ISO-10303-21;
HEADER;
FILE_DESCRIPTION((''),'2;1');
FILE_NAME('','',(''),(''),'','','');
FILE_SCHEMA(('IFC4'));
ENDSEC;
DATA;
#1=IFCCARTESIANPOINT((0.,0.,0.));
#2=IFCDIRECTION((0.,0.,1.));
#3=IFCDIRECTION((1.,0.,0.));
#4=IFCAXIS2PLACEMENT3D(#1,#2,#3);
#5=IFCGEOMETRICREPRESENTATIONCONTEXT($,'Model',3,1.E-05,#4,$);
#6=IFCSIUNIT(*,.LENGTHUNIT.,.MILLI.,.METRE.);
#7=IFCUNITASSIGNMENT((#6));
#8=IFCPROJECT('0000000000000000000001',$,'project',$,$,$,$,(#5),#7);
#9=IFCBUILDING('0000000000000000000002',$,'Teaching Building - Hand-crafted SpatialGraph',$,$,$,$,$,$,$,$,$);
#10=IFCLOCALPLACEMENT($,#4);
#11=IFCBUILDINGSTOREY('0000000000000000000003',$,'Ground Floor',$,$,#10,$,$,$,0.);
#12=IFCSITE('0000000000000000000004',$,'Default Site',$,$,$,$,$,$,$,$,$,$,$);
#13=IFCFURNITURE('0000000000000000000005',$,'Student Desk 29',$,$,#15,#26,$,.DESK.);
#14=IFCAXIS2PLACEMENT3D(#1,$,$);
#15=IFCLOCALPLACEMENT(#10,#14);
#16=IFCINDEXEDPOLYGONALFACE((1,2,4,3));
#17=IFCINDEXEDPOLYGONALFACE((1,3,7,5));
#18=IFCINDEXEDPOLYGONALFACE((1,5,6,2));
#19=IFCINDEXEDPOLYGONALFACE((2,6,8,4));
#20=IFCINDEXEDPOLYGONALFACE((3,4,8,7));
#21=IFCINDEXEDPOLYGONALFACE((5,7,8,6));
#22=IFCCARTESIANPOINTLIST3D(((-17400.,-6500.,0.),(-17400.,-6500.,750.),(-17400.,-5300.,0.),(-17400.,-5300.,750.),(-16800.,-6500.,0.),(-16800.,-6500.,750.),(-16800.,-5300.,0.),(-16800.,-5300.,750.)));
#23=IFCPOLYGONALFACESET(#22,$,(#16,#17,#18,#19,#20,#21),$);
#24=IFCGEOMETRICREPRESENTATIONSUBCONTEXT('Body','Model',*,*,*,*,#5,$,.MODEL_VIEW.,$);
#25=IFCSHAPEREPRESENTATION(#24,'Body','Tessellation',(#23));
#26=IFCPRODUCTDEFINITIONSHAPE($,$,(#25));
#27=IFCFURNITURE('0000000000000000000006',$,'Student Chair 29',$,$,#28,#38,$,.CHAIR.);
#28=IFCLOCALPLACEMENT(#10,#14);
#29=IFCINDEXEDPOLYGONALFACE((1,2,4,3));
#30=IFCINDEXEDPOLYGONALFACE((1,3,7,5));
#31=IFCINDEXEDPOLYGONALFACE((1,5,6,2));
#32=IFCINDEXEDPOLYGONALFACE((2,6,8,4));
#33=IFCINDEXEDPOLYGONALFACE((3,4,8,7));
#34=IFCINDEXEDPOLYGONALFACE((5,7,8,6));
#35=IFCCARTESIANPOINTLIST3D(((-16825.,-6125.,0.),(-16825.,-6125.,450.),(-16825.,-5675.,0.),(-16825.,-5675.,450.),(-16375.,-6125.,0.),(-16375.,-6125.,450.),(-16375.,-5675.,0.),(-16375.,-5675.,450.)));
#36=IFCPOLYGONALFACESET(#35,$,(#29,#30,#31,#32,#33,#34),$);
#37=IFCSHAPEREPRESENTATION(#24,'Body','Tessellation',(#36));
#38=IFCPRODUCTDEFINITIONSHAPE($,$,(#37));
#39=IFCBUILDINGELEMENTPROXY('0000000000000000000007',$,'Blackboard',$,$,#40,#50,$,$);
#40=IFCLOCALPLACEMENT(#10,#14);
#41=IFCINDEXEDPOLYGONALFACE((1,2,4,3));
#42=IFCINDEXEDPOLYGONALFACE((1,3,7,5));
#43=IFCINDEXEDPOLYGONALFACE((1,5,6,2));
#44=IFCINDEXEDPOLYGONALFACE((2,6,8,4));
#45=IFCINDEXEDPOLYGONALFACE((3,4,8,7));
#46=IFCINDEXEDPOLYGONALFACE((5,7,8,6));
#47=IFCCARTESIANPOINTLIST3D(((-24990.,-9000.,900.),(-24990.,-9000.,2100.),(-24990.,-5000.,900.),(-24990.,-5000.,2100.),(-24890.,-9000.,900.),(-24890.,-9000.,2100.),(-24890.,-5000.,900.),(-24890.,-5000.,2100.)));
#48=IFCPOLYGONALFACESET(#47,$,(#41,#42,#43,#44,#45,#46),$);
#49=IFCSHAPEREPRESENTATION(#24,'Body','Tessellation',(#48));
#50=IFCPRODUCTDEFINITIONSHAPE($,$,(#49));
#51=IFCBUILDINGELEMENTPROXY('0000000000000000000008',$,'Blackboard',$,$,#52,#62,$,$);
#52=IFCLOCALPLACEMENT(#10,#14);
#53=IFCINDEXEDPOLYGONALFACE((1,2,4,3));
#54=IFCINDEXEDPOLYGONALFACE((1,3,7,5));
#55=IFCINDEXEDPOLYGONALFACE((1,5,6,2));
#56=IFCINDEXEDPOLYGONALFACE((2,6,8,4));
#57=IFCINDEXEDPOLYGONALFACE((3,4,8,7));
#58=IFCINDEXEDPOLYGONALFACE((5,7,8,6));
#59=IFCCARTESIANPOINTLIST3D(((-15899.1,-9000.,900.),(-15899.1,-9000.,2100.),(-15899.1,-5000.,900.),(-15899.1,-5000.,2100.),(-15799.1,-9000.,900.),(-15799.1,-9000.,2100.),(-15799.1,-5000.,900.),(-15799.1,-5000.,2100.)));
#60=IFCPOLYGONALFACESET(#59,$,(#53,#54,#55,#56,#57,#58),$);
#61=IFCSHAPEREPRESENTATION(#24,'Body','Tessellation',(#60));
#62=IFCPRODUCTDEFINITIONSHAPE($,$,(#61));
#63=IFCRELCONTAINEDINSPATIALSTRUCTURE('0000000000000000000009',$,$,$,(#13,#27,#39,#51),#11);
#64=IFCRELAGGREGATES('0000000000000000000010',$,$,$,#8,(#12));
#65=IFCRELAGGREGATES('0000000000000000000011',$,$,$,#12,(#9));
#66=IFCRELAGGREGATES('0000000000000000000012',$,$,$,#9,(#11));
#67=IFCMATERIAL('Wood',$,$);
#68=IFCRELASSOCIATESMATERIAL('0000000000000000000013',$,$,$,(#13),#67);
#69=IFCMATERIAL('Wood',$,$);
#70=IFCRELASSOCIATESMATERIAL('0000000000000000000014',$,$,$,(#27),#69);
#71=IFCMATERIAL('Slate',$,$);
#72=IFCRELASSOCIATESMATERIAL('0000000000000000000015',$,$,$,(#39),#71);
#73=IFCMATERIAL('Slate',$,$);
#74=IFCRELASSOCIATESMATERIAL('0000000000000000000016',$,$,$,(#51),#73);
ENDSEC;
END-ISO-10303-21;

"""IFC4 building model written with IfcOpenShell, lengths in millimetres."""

from ifc_helpers import new_model, si_unit, frame, origin_with_axes, origin_2d, place, context, subcontext, project, spatial, rectangle, extrude, material, element, save


model = new_model("IFC4")

# Units and contexts
model_context = context("Model", 3, precision=1e-05, world=origin_with_axes())
body_context = subcontext(model_context, "Body", "Model", "MODEL_VIEW")
ifc_project = project(units=[si_unit("LENGTHUNIT", "METRE", prefix="MILLI")], contexts=[model_context])

# Site, building, storey
site = spatial("IfcSite", under=ifc_project, Name="Default Site")
building = spatial("IfcBuilding", under=site, Name="Teaching Building - Hand-crafted SpatialGraph")
storey_placement = place(None, origin_with_axes())
storey = spatial("IfcBuildingStorey", under=building, at=storey_placement, Name="Ground Floor", Elevation=0.0)

# Furniture
ifc_material_1 = material(Name="Wood")
furniture_1_placement = place(storey_placement, frame((-17100.0, -5900.0, 0.0), z_axis=(0.0, 0.0, 1.0), x_axis=(0.0, 1.0, 0.0)))
element("IfcFurniture", 1, at=furniture_1_placement, inside=storey, material=ifc_material_1, Name="Student Desk 29", PredefinedType="DESK", context=body_context, shape_type="SweptSolid", body=[
    extrude(rectangle(XDim=1200.0, YDim=600.0, at=origin_2d()), origin_with_axes(), (0.0, 0.0, 1.0), 750.0),
])
ifc_material_2 = material(Name="Wood")
furniture_2_placement = place(storey_placement, frame((-16600.0, -5900.0, 0.0), z_axis=(0.0, 0.0, 1.0), x_axis=(1.0, 0.0, 0.0)))
element("IfcFurniture", 2, at=furniture_2_placement, inside=storey, material=ifc_material_2, Name="Student Chair 29", PredefinedType="CHAIR", context=body_context, shape_type="SweptSolid", body=[
    extrude(rectangle(XDim=450.0, YDim=450.0, at=origin_2d()), origin_with_axes(), (0.0, 0.0, 1.0), 450.0),
])

# Building element proxies
ifc_material_3 = material(Name="Slate")
proxy_1_placement = place(storey_placement, frame((-24940.0, -7000.0, 900.0), z_axis=(0.0, 0.0, 1.0), x_axis=(1.0, 0.0, 0.0)))
element("IfcBuildingElementProxy", 3, at=proxy_1_placement, inside=storey, material=ifc_material_3, Name="Blackboard", context=body_context, shape_type="SweptSolid", body=[
    extrude(rectangle(XDim=100.0, YDim=4000.0, at=origin_2d()), origin_with_axes(), (0.0, 0.0, 1.0), 1200.0),
])
ifc_material_4 = material(Name="Slate")
proxy_2_placement = place(storey_placement, frame((-15849.1, -7000.0, 900.0), z_axis=(0.0, 0.0, 1.0), x_axis=(1.0, 0.0, 0.0)))
element("IfcBuildingElementProxy", 4, at=proxy_2_placement, inside=storey, material=ifc_material_4, Name="Blackboard", context=body_context, shape_type="SweptSolid", body=[
    extrude(rectangle(XDim=100.0, YDim=4000.0, at=origin_2d()), origin_with_axes(), (0.0, 0.0, 1.0), 1200.0),
])

save(model, "model.ifc")
